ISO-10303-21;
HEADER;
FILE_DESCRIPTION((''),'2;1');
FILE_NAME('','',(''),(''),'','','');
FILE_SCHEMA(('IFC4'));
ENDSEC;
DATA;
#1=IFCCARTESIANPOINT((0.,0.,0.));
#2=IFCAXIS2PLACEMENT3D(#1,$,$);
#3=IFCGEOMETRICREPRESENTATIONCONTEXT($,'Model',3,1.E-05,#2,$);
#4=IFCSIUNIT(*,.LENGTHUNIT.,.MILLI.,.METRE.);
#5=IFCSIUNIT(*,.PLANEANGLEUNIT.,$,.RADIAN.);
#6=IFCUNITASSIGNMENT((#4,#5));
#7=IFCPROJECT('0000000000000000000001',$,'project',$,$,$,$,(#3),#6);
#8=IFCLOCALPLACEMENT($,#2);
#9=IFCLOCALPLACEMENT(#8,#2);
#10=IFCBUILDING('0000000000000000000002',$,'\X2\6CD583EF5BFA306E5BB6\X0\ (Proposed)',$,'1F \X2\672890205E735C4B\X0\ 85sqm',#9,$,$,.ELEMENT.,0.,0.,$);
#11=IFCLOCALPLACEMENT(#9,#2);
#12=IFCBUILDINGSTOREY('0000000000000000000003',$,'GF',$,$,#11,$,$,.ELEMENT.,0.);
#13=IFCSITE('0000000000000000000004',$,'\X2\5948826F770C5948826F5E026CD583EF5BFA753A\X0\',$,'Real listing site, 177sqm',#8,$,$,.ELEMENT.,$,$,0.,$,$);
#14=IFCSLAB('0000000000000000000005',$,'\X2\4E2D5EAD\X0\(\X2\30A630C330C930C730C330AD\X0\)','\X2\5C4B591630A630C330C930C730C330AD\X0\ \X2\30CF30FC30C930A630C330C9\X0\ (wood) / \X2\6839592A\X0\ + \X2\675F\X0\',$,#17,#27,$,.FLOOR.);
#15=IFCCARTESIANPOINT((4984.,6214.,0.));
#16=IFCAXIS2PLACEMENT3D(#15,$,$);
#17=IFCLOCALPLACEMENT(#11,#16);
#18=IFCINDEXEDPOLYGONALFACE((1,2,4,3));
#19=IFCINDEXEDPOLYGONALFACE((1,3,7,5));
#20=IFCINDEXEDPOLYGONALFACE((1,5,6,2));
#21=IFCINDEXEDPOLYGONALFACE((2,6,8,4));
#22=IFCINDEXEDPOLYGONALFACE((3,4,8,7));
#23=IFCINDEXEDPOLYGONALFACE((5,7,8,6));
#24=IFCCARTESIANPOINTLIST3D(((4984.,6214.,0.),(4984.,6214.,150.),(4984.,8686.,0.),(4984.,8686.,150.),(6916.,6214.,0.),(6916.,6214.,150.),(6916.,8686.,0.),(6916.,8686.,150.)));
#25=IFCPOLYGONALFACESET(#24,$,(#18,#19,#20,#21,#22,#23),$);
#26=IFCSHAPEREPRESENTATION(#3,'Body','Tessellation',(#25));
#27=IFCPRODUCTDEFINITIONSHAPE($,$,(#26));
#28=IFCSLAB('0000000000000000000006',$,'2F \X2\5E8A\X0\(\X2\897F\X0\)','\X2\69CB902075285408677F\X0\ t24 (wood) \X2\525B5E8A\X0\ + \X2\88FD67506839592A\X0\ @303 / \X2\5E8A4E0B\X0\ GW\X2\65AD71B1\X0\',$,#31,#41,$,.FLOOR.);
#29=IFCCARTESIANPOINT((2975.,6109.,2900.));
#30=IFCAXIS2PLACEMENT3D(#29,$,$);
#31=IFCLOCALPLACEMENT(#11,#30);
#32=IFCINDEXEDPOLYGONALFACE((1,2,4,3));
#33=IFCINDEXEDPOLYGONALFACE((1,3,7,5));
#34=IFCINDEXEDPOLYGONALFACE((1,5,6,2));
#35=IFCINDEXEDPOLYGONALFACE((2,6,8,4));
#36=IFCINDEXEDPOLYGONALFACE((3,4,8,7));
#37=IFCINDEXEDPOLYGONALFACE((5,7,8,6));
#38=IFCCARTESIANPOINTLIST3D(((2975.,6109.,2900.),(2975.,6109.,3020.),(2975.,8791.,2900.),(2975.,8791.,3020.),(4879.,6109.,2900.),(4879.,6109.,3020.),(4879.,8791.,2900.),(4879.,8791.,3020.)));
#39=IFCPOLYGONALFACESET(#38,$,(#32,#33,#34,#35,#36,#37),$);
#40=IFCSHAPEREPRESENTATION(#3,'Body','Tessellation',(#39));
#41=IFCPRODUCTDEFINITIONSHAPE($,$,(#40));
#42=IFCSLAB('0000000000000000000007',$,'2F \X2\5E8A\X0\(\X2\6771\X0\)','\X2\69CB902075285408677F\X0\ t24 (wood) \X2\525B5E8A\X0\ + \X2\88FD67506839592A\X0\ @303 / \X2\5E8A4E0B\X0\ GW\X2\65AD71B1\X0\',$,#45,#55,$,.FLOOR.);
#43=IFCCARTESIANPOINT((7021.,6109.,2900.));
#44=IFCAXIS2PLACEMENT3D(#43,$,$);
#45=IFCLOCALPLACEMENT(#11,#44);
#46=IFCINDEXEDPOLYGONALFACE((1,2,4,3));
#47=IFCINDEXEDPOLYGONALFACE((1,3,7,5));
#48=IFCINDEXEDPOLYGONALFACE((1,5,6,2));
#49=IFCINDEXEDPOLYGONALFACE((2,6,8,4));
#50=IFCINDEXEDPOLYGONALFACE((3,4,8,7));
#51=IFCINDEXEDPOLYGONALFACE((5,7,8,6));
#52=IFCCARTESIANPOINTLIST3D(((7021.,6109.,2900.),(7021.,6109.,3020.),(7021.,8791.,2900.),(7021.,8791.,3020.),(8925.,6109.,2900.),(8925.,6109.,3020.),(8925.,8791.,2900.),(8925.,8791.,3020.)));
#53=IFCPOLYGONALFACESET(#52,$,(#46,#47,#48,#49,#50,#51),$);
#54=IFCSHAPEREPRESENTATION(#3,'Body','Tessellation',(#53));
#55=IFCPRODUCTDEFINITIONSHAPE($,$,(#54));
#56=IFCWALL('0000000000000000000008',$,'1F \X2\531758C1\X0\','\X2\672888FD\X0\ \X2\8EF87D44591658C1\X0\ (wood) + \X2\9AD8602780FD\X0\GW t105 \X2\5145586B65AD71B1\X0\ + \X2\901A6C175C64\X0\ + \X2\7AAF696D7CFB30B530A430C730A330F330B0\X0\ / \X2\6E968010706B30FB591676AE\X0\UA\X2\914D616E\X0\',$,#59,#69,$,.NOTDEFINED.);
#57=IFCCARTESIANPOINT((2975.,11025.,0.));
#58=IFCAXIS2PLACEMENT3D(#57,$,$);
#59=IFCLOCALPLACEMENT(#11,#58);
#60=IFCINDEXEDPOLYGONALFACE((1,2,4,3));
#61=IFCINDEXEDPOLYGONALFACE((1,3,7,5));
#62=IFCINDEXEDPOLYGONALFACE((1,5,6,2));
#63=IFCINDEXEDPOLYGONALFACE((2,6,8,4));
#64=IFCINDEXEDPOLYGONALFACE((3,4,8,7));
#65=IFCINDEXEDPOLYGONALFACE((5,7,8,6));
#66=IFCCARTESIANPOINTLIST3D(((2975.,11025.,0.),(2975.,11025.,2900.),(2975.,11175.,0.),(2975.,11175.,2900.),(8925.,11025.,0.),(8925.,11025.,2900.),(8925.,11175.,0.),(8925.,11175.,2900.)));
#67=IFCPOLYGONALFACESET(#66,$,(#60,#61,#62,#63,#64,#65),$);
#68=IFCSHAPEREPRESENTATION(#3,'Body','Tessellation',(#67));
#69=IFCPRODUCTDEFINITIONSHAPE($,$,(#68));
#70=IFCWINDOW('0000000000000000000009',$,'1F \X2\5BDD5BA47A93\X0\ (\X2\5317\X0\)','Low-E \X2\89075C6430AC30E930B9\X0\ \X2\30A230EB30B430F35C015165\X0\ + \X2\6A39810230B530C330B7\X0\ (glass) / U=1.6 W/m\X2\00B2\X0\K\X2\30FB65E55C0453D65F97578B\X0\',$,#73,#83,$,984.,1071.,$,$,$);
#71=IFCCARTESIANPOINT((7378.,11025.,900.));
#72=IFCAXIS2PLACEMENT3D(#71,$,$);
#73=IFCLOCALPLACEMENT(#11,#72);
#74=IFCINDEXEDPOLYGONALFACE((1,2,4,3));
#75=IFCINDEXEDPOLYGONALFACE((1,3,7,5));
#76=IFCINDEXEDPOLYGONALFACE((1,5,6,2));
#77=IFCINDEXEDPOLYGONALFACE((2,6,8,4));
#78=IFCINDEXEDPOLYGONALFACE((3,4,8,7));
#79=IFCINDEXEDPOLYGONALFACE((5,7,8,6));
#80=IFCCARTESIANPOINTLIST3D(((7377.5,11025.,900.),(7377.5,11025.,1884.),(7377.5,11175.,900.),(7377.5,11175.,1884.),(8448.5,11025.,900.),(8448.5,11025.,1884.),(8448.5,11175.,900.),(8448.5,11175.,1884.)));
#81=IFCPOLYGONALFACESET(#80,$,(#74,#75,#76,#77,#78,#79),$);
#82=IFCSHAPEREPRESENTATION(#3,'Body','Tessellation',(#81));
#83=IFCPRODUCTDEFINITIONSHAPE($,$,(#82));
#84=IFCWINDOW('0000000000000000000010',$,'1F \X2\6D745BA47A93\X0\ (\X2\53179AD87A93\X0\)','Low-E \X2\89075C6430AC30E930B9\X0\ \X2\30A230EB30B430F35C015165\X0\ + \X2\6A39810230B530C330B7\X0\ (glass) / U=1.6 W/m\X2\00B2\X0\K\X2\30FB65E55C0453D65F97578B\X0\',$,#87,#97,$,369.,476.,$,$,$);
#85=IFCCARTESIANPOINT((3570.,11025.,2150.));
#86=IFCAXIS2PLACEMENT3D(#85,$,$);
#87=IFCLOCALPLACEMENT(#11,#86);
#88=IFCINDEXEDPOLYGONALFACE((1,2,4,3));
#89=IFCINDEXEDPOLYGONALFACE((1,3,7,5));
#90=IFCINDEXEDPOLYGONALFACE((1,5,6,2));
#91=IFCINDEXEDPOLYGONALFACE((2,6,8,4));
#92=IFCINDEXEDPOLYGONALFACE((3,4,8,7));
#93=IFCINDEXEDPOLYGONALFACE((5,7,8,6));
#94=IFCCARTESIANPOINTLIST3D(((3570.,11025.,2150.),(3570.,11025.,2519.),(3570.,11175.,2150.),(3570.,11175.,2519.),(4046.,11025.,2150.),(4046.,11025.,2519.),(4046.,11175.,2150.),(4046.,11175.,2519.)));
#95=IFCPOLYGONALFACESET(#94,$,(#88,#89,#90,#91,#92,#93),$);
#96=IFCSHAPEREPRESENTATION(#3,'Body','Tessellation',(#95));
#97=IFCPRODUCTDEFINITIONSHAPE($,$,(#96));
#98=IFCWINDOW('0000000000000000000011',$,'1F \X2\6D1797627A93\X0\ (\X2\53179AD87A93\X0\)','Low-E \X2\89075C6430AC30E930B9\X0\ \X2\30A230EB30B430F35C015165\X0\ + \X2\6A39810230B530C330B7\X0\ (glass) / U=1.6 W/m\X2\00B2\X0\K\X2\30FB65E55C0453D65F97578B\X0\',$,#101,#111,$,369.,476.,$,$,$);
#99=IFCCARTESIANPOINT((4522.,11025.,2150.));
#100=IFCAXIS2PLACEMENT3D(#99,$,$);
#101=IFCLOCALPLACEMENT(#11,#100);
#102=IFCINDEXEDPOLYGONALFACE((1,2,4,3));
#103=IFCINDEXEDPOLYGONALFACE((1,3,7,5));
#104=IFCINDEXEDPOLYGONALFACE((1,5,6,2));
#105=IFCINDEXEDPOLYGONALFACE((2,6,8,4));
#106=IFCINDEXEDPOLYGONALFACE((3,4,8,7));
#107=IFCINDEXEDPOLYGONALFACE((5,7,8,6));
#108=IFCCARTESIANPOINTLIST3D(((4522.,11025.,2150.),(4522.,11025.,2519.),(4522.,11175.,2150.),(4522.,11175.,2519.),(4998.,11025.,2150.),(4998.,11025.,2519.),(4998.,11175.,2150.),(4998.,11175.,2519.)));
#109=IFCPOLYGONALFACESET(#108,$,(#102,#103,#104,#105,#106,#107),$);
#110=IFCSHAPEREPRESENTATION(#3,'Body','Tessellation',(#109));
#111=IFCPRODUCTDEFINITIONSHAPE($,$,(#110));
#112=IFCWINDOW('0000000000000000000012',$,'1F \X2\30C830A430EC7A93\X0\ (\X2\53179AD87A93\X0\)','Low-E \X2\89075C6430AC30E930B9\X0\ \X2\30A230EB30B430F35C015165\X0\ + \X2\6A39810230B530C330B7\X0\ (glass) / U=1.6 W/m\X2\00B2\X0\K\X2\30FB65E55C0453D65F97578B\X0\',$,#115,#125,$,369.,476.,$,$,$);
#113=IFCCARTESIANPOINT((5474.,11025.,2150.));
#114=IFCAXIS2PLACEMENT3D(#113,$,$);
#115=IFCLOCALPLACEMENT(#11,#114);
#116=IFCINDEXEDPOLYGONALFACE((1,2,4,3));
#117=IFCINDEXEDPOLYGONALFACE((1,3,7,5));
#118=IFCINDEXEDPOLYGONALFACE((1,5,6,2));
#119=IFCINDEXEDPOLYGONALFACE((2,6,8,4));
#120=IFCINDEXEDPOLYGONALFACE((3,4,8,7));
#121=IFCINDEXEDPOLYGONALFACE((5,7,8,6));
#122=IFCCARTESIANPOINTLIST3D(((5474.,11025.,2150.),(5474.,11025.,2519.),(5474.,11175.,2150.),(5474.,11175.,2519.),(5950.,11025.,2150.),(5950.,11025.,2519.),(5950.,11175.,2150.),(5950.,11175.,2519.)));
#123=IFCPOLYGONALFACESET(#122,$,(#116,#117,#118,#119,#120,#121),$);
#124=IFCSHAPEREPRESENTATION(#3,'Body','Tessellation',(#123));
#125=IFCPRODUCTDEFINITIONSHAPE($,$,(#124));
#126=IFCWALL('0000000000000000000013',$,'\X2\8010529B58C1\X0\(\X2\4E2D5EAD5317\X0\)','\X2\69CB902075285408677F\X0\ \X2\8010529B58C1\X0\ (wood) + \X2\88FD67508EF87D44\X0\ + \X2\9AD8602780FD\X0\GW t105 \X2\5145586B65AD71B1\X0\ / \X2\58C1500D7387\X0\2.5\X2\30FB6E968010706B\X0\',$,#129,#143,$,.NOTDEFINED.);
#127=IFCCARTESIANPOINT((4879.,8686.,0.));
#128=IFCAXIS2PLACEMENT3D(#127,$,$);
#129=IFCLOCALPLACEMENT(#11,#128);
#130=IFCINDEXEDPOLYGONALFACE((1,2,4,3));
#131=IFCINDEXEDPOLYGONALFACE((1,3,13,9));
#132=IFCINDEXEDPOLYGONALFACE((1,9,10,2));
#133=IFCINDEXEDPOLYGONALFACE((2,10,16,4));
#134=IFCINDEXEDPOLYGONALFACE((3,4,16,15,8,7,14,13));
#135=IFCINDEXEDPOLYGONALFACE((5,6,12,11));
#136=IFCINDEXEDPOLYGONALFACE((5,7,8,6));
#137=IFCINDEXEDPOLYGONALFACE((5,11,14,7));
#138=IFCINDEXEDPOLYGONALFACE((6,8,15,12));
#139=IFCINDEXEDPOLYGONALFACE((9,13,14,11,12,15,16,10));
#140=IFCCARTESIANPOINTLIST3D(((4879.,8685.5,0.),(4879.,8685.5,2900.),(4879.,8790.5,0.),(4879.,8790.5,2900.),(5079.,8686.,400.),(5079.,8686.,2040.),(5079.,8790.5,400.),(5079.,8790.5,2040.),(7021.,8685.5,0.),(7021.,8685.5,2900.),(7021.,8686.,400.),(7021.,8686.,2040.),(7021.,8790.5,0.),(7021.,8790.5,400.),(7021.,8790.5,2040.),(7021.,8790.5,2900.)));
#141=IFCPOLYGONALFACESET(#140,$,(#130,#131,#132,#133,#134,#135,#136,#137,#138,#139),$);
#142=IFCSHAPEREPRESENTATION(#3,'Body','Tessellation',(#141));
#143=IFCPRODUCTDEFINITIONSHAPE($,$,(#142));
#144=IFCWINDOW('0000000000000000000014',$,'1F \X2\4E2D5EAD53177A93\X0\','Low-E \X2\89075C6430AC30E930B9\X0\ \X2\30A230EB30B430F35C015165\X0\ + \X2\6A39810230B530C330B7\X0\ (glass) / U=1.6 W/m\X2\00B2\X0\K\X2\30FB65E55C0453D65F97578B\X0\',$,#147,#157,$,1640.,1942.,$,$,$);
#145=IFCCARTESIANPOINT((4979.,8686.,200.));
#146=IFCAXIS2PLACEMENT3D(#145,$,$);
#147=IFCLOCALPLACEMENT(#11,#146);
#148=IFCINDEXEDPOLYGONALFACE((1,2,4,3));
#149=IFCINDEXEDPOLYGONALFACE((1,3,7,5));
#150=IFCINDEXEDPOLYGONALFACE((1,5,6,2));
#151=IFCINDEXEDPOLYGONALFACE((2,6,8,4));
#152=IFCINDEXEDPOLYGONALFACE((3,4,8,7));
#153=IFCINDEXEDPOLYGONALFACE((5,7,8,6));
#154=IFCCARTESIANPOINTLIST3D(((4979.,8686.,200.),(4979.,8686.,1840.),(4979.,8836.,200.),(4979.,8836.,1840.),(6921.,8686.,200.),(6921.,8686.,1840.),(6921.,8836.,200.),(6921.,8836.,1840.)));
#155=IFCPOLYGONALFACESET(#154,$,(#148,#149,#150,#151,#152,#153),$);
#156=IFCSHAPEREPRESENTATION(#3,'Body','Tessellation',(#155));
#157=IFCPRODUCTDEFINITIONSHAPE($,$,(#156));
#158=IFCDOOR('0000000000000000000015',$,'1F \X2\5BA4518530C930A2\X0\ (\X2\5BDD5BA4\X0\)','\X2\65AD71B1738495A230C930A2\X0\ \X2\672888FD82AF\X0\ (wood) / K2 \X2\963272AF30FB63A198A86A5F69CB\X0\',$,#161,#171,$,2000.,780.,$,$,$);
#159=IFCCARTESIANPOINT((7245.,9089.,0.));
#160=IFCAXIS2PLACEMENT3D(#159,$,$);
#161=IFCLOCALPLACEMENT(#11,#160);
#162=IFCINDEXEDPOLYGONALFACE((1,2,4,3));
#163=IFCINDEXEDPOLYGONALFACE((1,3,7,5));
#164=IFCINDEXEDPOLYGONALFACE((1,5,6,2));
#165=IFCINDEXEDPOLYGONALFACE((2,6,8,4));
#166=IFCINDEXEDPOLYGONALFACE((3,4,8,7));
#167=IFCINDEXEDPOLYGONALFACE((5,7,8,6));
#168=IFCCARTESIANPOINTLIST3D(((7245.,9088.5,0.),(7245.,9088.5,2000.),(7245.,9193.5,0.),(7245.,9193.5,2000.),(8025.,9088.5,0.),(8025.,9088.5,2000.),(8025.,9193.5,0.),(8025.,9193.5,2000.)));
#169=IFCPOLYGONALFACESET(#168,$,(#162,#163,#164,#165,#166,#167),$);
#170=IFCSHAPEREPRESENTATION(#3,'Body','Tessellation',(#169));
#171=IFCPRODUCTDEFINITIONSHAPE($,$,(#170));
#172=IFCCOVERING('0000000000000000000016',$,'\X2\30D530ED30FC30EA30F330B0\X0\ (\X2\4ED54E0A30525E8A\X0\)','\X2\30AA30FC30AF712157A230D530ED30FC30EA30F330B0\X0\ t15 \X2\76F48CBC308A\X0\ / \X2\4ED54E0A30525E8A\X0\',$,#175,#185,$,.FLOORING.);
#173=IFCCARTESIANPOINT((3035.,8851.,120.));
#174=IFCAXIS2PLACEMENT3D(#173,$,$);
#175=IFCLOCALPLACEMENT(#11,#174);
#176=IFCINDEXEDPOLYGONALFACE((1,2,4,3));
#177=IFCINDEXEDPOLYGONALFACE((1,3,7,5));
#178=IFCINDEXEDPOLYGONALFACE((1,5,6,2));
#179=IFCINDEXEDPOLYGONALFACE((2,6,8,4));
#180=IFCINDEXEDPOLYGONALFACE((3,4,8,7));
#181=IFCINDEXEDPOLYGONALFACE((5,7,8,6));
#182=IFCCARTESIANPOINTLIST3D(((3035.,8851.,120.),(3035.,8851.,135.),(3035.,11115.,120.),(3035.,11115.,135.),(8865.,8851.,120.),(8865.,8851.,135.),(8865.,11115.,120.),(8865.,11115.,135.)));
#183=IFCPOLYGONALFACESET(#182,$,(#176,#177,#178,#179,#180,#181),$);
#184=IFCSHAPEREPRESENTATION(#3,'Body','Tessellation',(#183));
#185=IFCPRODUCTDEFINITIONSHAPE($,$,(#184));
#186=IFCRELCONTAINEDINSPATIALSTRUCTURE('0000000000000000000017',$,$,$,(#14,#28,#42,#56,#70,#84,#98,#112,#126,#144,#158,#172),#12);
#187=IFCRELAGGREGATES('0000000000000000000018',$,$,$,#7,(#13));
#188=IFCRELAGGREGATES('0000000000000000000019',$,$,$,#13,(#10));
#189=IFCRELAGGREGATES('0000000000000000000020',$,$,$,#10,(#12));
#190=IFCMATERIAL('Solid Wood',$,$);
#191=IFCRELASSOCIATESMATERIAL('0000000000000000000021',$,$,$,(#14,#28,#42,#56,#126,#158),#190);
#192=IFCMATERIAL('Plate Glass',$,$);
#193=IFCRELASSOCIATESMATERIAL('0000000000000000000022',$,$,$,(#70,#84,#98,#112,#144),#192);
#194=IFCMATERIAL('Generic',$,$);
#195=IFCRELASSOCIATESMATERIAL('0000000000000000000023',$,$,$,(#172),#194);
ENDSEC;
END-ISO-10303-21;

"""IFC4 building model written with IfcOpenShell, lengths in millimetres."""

from ifc_helpers import new_model, si_unit, frame, frame_2d, origin, place, context, project, spatial, rectangle, extrude, material, element, fill, save


model = new_model("IFC4")

# Units and contexts
model_context = context("Model", 3, precision=1e-05, world=origin())
ifc_project = project(units=[si_unit("LENGTHUNIT", "METRE", prefix="MILLI"), si_unit("PLANEANGLEUNIT", "RADIAN")], contexts=[model_context])

# Site, building, storey
site_placement = place(None, origin())
site = spatial("IfcSite", under=ifc_project, at=site_placement, Name="奈良県奈良市法華寺町", ObjectType="Real listing site, 177sqm", CompositionType="ELEMENT", RefElevation=0.0)
building_placement = place(site_placement, origin())
building = spatial("IfcBuilding", under=site, at=building_placement, Name="法華寺の家 (Proposed)", ObjectType="1F 木造平屋 85sqm", CompositionType="ELEMENT", ElevationOfRefHeight=0.0, ElevationOfTerrain=0.0)
storey_placement = place(building_placement, origin())
storey = spatial("IfcBuildingStorey", under=building, at=storey_placement, Name="GF", CompositionType="ELEMENT", Elevation=0.0)

# Slabs
ifc_material_1 = material(Name="Solid Wood")
slab_1_placement = place(storey_placement, frame((4984.0, 6214.0, 0.0)))
element("IfcSlab", 1, at=slab_1_placement, inside=storey, material=ifc_material_1, Name="中庭(ウッドデッキ)", Description="屋外ウッドデッキ ハードウッド (wood) / 根太 + 束", PredefinedType="FLOOR", context=model_context, shape_type="SweptSolid", body=[
    extrude(rectangle(XDim=1932.0, YDim=2472.0, at=frame_2d((966.0, 1236.0))), frame((4984.0, 6214.0, 0.0)), (0.0, 0.0, 1.0), 150.0),
])
slab_2_placement = place(storey_placement, frame((2975.0, 6109.0, 2900.0)))
element("IfcSlab", 2, at=slab_2_placement, inside=storey, material=ifc_material_1, Name="2F 床(西)", Description="構造用合板 t24 (wood) 剛床 + 製材根太 @303 / 床下 GW断熱", PredefinedType="FLOOR", context=model_context, shape_type="SweptSolid", body=[
    extrude(rectangle(XDim=1904.0, YDim=2682.0, at=frame_2d((952.0, 1341.0))), frame((2975.0, 6109.0, 2900.0)), (0.0, 0.0, 1.0), 120.0),
])
slab_3_placement = place(storey_placement, frame((7021.0, 6109.0, 2900.0)))
element("IfcSlab", 3, at=slab_3_placement, inside=storey, material=ifc_material_1, Name="2F 床(東)", Description="構造用合板 t24 (wood) 剛床 + 製材根太 @303 / 床下 GW断熱", PredefinedType="FLOOR", context=model_context, shape_type="SweptSolid", body=[
    extrude(rectangle(XDim=1904.0, YDim=2682.0, at=frame_2d((952.0, 1341.0))), frame((7021.0, 6109.0, 2900.0)), (0.0, 0.0, 1.0), 120.0),
])

# Wall, openings, windows
wall_1_placement = place(storey_placement, frame((2975.0, 11025.0, 0.0)))
wall_1 = element("IfcWall", 4, at=wall_1_placement, inside=storey, material=ifc_material_1, Name="1F 北壁", Description="木製 軸組外壁 (wood) + 高性能GW t105 充填断熱 + 通気層 + 窯業系サイディング / 準耐火・外皮UA配慮", PredefinedType="NOTDEFINED", context=model_context, shape_type="SweptSolid", body=[
    extrude(rectangle(XDim=5950.0, YDim=150.0, at=frame_2d((2975.0, 75.0))), frame((2975.0, 11025.0, 0.0)), (0.0, 0.0, 1.0), 2900.0),
])
opening_1_placement = place(storey_placement, frame((7378.0, 11025.0, 900.0)))
opening_1 = element("IfcOpeningElement", 5, at=opening_1_placement, cuts=wall_1, PredefinedType="NOTDEFINED", context=model_context, shape_type="SweptSolid", body=[
    extrude(rectangle(XDim=1071.0, YDim=150.0, at=frame_2d((535.0, 75.0))), frame((7378.0, 11025.0, 900.0)), (0.0, 0.0, 1.0), 984.0),
])
opening_2_placement = place(storey_placement, frame((3570.0, 11025.0, 2150.0)))
opening_2 = element("IfcOpeningElement", 6, at=opening_2_placement, cuts=wall_1, PredefinedType="NOTDEFINED", context=model_context, shape_type="SweptSolid", body=[
    extrude(rectangle(XDim=476.0, YDim=150.0, at=frame_2d((238.0, 75.0))), frame((3570.0, 11025.0, 2150.0)), (0.0, 0.0, 1.0), 369.0),
])
opening_3_placement = place(storey_placement, frame((4522.0, 11025.0, 2150.0)))
opening_3 = element("IfcOpeningElement", 7, at=opening_3_placement, cuts=wall_1, PredefinedType="NOTDEFINED", context=model_context, shape_type="SweptSolid", body=[
    extrude(rectangle(XDim=476.0, YDim=150.0, at=frame_2d((238.0, 75.0))), frame((4522.0, 11025.0, 2150.0)), (0.0, 0.0, 1.0), 369.0),
])
opening_4_placement = place(storey_placement, frame((5474.0, 11025.0, 2150.0)))
opening_4 = element("IfcOpeningElement", 8, at=opening_4_placement, cuts=wall_1, PredefinedType="NOTDEFINED", context=model_context, shape_type="SweptSolid", body=[
    extrude(rectangle(XDim=476.0, YDim=150.0, at=frame_2d((238.0, 75.0))), frame((5474.0, 11025.0, 2150.0)), (0.0, 0.0, 1.0), 369.0),
])
ifc_material_2 = material(Name="Plate Glass")
window_1_placement = place(storey_placement, frame((7378.0, 11025.0, 900.0)))
window_1 = element("IfcWindow", 9, at=window_1_placement, inside=storey, material=ifc_material_2, Name="1F 寝室窓 (北)", Description="Low-E 複層ガラス アルゴン封入 + 樹脂サッシ (glass) / U=1.6 W/m²K・日射取得型", OverallHeight=984.0, OverallWidth=1071.0, context=model_context, shape_type="SweptSolid", body=[
    extrude(rectangle(XDim=1071.0, YDim=150.0, at=frame_2d((535.0, 75.0))), frame((7378.0, 11025.0, 900.0)), (0.0, 0.0, 1.0), 984.0),
])
fill(opening_1, window_1)
window_2_placement = place(storey_placement, frame((3570.0, 11025.0, 2150.0)))
window_2 = element("IfcWindow", 10, at=window_2_placement, inside=storey, material=ifc_material_2, Name="1F 浴室窓 (北高窓)", Description="Low-E 複層ガラス アルゴン封入 + 樹脂サッシ (glass) / U=1.6 W/m²K・日射取得型", OverallHeight=369.0, OverallWidth=476.0, context=model_context, shape_type="SweptSolid", body=[
    extrude(rectangle(XDim=476.0, YDim=150.0, at=frame_2d((238.0, 75.0))), frame((3570.0, 11025.0, 2150.0)), (0.0, 0.0, 1.0), 369.0),
])
fill(opening_2, window_2)
window_3_placement = place(storey_placement, frame((4522.0, 11025.0, 2150.0)))
window_3 = element("IfcWindow", 11, at=window_3_placement, inside=storey, material=ifc_material_2, Name="1F 洗面窓 (北高窓)", Description="Low-E 複層ガラス アルゴン封入 + 樹脂サッシ (glass) / U=1.6 W/m²K・日射取得型", OverallHeight=369.0, OverallWidth=476.0, context=model_context, shape_type="SweptSolid", body=[
    extrude(rectangle(XDim=476.0, YDim=150.0, at=frame_2d((238.0, 75.0))), frame((4522.0, 11025.0, 2150.0)), (0.0, 0.0, 1.0), 369.0),
])
fill(opening_3, window_3)
window_4_placement = place(storey_placement, frame((5474.0, 11025.0, 2150.0)))
window_4 = element("IfcWindow", 12, at=window_4_placement, inside=storey, material=ifc_material_2, Name="1F トイレ窓 (北高窓)", Description="Low-E 複層ガラス アルゴン封入 + 樹脂サッシ (glass) / U=1.6 W/m²K・日射取得型", OverallHeight=369.0, OverallWidth=476.0, context=model_context, shape_type="SweptSolid", body=[
    extrude(rectangle(XDim=476.0, YDim=150.0, at=frame_2d((238.0, 75.0))), frame((5474.0, 11025.0, 2150.0)), (0.0, 0.0, 1.0), 369.0),
])
fill(opening_4, window_4)

# Wall, opening, window
wall_2_placement = place(storey_placement, frame((4879.0, 8686.0, 0.0)))
wall_2 = element("IfcWall", 13, at=wall_2_placement, inside=storey, material=ifc_material_1, Name="耐力壁(中庭北)", Description="構造用合板 耐力壁 (wood) + 製材軸組 + 高性能GW t105 充填断熱 / 壁倍率2.5・準耐火", PredefinedType="NOTDEFINED", context=model_context, shape_type="SweptSolid", body=[
    extrude(rectangle(XDim=2142.0, YDim=105.0, at=frame_2d((1071.0, 52.0))), frame((4879.0, 8686.0, 0.0)), (0.0, 0.0, 1.0), 2900.0),
])
opening_5_placement = place(storey_placement, frame((4979.0, 8686.0, 200.0)))
opening_5 = element("IfcOpeningElement", 14, at=opening_5_placement, cuts=wall_2, PredefinedType="NOTDEFINED", context=model_context, shape_type="SweptSolid", body=[
    extrude(rectangle(XDim=1942.0, YDim=150.0, at=frame_2d((971.0, 75.0))), frame((4979.0, 8686.0, 200.0)), (0.0, 0.0, 1.0), 1640.0),
])
window_5_placement = place(storey_placement, frame((4979.0, 8686.0, 200.0)))
window_5 = element("IfcWindow", 15, at=window_5_placement, inside=storey, material=ifc_material_2, Name="1F 中庭北窓", Description="Low-E 複層ガラス アルゴン封入 + 樹脂サッシ (glass) / U=1.6 W/m²K・日射取得型", OverallHeight=1640.0, OverallWidth=1942.0, context=model_context, shape_type="SweptSolid", body=[
    extrude(rectangle(XDim=1942.0, YDim=150.0, at=frame_2d((971.0, 75.0))), frame((4979.0, 8686.0, 200.0)), (0.0, 0.0, 1.0), 1640.0),
])
fill(opening_5, window_5)

# Door
door_1_placement = place(storey_placement, frame((7245.0, 9089.0, 0.0)))
element("IfcDoor", 16, at=door_1_placement, inside=storey, material=ifc_material_1, Name="1F 室内ドア (寝室)", Description="断熱玄関ドア 木製芯 (wood) / K2 防犯・採風機構", OverallHeight=2000.0, OverallWidth=780.0, context=model_context, shape_type="SweptSolid", body=[
    extrude(rectangle(XDim=780.0, YDim=105.0, at=frame_2d((390.0, 52.0))), frame((7245.0, 9089.0, 0.0)), (0.0, 0.0, 1.0), 2000.0),
])

# Covering
ifc_material_3 = material(Name="Generic")
covering_1_placement = place(storey_placement, frame((3035.0, 8851.0, 120.0)))
element("IfcCovering", 17, at=covering_1_placement, inside=storey, material=ifc_material_3, Name="フローリング (仕上げ床)", Description="オーク無垢フローリング t15 直貼り / 仕上げ床", PredefinedType="FLOORING", context=model_context, shape_type="SweptSolid", body=[
    extrude(rectangle(XDim=5830.0, YDim=2264.0, at=frame_2d((2915.0, 1132.0))), frame((3035.0, 8851.0, 120.0)), (0.0, 0.0, 1.0), 15.0),
])

save(model, "model.ifc")
